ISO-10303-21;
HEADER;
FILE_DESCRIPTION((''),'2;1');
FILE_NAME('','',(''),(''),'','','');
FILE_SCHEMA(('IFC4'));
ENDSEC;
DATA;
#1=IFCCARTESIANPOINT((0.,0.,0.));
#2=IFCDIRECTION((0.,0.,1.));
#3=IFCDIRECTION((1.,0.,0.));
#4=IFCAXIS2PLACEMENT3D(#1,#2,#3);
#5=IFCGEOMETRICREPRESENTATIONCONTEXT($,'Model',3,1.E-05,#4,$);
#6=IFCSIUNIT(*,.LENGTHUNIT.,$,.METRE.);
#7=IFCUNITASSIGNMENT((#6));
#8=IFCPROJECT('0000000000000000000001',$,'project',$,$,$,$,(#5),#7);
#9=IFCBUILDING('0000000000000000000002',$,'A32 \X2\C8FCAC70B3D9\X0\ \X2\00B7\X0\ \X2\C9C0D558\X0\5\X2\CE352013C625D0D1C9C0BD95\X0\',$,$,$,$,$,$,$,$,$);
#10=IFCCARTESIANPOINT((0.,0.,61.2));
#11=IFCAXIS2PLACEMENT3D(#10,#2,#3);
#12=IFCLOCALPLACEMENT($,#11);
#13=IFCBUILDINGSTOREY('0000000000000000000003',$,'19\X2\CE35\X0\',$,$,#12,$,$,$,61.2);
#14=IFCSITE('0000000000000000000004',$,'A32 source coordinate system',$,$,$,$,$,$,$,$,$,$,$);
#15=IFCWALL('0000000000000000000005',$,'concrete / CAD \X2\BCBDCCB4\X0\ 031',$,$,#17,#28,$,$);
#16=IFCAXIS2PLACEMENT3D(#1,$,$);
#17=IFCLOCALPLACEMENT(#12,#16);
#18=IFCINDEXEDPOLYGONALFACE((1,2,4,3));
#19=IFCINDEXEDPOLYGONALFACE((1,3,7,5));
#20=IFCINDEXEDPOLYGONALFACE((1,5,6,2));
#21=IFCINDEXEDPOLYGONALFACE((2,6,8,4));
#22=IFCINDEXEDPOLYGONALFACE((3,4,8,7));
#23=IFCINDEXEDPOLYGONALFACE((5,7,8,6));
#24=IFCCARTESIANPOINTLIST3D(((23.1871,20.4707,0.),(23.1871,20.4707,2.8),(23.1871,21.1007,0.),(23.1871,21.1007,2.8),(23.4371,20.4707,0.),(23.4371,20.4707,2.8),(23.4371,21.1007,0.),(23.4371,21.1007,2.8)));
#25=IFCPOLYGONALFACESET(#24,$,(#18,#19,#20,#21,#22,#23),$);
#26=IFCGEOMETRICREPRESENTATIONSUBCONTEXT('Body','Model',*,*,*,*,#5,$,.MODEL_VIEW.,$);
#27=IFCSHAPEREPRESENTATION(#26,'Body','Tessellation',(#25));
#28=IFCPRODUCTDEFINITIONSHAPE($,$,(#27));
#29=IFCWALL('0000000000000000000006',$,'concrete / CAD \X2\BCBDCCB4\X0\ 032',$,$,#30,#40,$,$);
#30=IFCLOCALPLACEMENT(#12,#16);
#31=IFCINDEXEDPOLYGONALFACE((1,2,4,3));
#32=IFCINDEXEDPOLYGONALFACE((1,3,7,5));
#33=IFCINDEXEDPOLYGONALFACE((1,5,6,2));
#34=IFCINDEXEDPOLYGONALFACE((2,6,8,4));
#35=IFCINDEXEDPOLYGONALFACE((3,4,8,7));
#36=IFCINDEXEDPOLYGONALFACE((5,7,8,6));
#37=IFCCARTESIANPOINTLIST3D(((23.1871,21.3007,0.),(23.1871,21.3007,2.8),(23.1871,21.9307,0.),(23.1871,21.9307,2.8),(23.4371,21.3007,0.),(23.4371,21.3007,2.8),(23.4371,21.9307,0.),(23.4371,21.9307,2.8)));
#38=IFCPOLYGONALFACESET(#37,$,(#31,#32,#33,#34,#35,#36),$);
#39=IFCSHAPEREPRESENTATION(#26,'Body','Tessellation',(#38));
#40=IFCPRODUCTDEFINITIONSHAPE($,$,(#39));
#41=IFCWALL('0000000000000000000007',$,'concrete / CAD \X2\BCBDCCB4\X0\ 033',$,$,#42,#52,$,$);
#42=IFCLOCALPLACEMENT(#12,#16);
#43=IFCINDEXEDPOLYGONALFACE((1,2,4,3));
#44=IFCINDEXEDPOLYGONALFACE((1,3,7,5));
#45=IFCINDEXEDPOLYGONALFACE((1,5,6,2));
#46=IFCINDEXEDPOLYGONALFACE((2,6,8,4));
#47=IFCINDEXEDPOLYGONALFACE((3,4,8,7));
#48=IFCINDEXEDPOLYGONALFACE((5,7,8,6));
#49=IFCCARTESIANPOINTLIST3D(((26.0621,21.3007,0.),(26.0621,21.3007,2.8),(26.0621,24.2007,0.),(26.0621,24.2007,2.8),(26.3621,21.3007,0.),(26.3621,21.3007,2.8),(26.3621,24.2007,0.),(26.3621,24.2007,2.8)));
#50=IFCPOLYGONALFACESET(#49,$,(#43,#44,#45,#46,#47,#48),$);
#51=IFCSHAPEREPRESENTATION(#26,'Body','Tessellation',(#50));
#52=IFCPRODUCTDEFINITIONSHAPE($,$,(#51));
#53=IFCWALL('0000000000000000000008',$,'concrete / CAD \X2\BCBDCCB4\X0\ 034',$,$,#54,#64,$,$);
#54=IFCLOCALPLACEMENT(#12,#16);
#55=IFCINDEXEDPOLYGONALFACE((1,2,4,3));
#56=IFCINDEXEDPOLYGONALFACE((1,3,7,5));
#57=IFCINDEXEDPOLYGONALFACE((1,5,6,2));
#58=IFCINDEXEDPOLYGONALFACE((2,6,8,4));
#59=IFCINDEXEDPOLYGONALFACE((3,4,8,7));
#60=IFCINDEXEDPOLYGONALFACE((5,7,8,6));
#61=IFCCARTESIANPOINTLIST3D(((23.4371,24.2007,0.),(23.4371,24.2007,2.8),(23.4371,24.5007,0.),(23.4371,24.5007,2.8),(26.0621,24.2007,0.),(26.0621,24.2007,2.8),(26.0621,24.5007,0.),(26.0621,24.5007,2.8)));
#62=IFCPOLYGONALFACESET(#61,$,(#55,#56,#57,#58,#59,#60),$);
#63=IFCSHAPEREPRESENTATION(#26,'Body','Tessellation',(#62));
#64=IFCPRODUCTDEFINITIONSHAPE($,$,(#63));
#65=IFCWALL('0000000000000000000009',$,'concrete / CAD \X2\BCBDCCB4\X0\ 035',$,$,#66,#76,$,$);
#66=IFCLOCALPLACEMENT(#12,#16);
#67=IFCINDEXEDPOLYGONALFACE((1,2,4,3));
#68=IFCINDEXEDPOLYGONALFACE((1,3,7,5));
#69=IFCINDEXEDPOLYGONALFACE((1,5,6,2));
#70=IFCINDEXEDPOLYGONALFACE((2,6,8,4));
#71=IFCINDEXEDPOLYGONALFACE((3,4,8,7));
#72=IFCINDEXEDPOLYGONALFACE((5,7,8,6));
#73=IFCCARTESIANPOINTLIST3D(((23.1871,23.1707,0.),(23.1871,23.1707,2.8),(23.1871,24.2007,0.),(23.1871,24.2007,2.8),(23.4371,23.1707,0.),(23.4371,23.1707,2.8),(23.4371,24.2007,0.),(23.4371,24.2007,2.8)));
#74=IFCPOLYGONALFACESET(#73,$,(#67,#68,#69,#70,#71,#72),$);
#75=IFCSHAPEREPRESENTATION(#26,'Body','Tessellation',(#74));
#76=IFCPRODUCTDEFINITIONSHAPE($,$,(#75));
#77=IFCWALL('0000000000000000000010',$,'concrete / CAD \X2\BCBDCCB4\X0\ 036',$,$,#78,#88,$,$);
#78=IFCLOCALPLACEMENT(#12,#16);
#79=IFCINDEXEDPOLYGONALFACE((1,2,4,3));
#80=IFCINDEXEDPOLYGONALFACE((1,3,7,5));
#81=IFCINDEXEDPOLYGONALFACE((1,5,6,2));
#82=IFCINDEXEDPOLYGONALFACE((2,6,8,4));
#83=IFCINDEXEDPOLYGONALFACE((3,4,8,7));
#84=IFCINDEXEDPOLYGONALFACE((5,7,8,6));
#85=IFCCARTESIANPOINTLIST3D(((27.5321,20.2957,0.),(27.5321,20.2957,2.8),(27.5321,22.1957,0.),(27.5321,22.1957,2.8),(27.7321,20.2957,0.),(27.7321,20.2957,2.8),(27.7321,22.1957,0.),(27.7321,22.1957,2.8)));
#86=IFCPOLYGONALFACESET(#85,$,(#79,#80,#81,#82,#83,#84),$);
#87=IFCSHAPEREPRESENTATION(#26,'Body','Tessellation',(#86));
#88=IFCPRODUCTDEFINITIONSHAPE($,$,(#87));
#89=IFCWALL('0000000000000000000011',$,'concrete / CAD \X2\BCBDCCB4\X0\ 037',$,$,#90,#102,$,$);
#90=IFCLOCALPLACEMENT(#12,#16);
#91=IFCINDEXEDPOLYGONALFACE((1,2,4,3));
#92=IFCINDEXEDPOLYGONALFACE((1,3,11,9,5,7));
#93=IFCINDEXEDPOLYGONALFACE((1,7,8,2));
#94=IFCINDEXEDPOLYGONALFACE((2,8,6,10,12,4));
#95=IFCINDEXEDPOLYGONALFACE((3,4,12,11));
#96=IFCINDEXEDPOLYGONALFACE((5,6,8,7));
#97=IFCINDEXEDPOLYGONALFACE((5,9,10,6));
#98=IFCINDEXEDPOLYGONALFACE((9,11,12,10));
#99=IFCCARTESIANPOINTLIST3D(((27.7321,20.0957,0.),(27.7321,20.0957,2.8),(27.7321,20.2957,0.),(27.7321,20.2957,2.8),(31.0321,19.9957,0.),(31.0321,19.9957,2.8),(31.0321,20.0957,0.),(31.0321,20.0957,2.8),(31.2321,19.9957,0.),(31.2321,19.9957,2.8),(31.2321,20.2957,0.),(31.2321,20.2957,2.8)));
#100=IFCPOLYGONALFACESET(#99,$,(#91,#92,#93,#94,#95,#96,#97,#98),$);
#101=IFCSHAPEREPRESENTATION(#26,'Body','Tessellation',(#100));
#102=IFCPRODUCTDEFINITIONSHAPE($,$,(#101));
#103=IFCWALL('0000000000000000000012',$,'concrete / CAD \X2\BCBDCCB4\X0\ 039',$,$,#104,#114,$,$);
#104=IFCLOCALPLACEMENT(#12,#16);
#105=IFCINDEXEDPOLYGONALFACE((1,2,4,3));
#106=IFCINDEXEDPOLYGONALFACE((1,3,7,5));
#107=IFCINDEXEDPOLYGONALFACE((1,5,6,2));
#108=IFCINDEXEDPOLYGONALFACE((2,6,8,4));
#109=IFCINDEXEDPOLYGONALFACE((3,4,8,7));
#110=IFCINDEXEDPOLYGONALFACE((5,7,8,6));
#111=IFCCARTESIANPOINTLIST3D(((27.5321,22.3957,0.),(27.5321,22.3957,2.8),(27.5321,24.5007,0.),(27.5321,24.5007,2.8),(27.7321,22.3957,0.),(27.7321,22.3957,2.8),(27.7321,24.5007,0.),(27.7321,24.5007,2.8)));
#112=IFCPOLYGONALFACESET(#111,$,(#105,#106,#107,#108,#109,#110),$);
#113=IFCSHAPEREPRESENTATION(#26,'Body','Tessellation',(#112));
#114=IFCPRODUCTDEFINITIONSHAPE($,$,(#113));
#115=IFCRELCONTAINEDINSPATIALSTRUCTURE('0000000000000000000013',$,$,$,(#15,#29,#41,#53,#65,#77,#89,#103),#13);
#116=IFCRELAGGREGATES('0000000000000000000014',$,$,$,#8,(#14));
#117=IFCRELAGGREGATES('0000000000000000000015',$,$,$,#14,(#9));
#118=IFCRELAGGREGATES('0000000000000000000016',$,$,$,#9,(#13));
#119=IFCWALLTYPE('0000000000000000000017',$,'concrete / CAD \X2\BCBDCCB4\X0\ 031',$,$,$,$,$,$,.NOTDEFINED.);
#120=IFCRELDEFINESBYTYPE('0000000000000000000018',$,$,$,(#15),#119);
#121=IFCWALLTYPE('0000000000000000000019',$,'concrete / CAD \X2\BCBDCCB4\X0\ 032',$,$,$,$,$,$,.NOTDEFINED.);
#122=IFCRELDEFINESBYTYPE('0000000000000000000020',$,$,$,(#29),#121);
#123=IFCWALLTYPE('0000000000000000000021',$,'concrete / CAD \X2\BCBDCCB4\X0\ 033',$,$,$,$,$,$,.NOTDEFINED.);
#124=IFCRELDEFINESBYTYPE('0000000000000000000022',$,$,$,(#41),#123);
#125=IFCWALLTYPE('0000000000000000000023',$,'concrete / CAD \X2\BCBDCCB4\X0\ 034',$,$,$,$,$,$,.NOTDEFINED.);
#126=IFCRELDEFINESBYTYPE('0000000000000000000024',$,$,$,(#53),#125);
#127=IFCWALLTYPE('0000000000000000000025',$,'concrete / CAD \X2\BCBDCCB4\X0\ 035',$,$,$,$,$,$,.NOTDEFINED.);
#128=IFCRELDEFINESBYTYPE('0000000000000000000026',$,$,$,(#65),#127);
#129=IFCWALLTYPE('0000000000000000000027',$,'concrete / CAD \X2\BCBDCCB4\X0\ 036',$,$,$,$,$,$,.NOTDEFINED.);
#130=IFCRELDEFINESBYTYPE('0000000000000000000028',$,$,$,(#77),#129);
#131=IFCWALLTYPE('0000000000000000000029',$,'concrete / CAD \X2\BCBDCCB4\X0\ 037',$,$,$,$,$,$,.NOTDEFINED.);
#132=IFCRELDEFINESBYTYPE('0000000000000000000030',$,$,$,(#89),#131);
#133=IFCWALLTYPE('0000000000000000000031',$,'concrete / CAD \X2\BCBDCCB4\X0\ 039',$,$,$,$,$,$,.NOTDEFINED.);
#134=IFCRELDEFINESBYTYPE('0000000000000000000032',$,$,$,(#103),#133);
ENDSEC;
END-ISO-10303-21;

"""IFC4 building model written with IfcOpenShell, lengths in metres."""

from ifc_helpers import new_model, si_unit, frame, origin, origin_with_axes, place, context, subcontext, project, spatial, polyline, outline, extrude, source, transform, mapped, type_object, type_shapes, element, save


model = new_model("IFC4")

# Units and contexts
model_context = context("Model", 3, precision=1e-05, world=origin_with_axes())
body_context = subcontext(model_context, "Body", "Model", "MODEL_VIEW")
ifc_project = project(units=[si_unit("LENGTHUNIT", "METRE")], contexts=[model_context])

# Site, building, storey
site = spatial("IfcSite", under=ifc_project, Name="A32 source coordinate system")
building = spatial("IfcBuilding", under=site, Name="A32 주거동 · 지하5층–옥탑지붕")
storey_placement = place(None, frame((0.0, 0.0, 61.2), z_axis=(0.0, 0.0, 1.0), x_axis=(1.0, 0.0, 0.0)))
storey = spatial("IfcBuildingStorey", under=building, at=storey_placement, Name="19층", Elevation=61.2)

# Walls
wall_type_1 = type_object("IfcWallType", Name="concrete / CAD 벽체 031", PredefinedType="NOTDEFINED")
shared_shape_1 = source(origin(), body_context, "Body", "SweptSolid", [
    extrude(outline(polyline([(23.1871, 20.4707), (23.1871, 21.1007), (23.4371, 21.1007), (23.4371, 20.4707), (23.1871, 20.4707)])), origin(), (0.0, 0.0, 1.0), 2.8),
])
type_shapes(wall_type_1, [shared_shape_1])
wall_1_placement = place(storey_placement, origin_with_axes())
element("IfcWall", 1, at=wall_1_placement, inside=storey, type_object=wall_type_1, Name="concrete / CAD 벽체 031", context=body_context, shape_type="MappedRepresentation", body=[
    mapped(shared_shape_1, transform((0.0, 0.0, 0.0), scale=1.0)),
])
wall_type_2 = type_object("IfcWallType", Name="concrete / CAD 벽체 032", PredefinedType="NOTDEFINED")
shared_shape_2 = source(origin(), body_context, "Body", "SweptSolid", [
    extrude(outline(polyline([(23.4371, 21.9307), (23.4371, 21.3007), (23.1871, 21.3007), (23.1871, 21.9307), (23.4371, 21.9307)])), origin(), (0.0, 0.0, 1.0), 2.8),
])
type_shapes(wall_type_2, [shared_shape_2])
wall_2_placement = place(storey_placement, origin_with_axes())
element("IfcWall", 2, at=wall_2_placement, inside=storey, type_object=wall_type_2, Name="concrete / CAD 벽체 032", context=body_context, shape_type="MappedRepresentation", body=[
    mapped(shared_shape_2, transform((0.0, 0.0, 0.0), scale=1.0)),
])
wall_type_3 = type_object("IfcWallType", Name="concrete / CAD 벽체 033", PredefinedType="NOTDEFINED")
shared_shape_3 = source(origin(), body_context, "Body", "SweptSolid", [
    extrude(outline(polyline([(26.3621, 24.2007), (26.3621, 21.3007), (26.0621, 21.3007), (26.0621, 24.2007), (26.3621, 24.2007)])), origin(), (0.0, 0.0, 1.0), 2.8),
])
type_shapes(wall_type_3, [shared_shape_3])
wall_3_placement = place(storey_placement, origin_with_axes())
element("IfcWall", 3, at=wall_3_placement, inside=storey, type_object=wall_type_3, Name="concrete / CAD 벽체 033", context=body_context, shape_type="MappedRepresentation", body=[
    mapped(shared_shape_3, transform((0.0, 0.0, 0.0), scale=1.0)),
])
wall_type_4 = type_object("IfcWallType", Name="concrete / CAD 벽체 034", PredefinedType="NOTDEFINED")
shared_shape_4 = source(origin(), body_context, "Body", "SweptSolid", [
    extrude(outline(polyline([(23.4371, 24.5007), (26.0621, 24.5007), (26.0621, 24.2007), (23.4371, 24.2007), (23.4371, 24.5007)])), origin(), (0.0, 0.0, 1.0), 2.8),
])
type_shapes(wall_type_4, [shared_shape_4])
wall_4_placement = place(storey_placement, origin_with_axes())
element("IfcWall", 4, at=wall_4_placement, inside=storey, type_object=wall_type_4, Name="concrete / CAD 벽체 034", context=body_context, shape_type="MappedRepresentation", body=[
    mapped(shared_shape_4, transform((0.0, 0.0, 0.0), scale=1.0)),
])
wall_type_5 = type_object("IfcWallType", Name="concrete / CAD 벽체 035", PredefinedType="NOTDEFINED")
shared_shape_5 = source(origin(), body_context, "Body", "SweptSolid", [
    extrude(outline(polyline([(23.1871, 23.1707), (23.1871, 24.2007), (23.4371, 24.2007), (23.4371, 23.1707), (23.1871, 23.1707)])), origin(), (0.0, 0.0, 1.0), 2.8),
])
type_shapes(wall_type_5, [shared_shape_5])
wall_5_placement = place(storey_placement, origin_with_axes())
element("IfcWall", 5, at=wall_5_placement, inside=storey, type_object=wall_type_5, Name="concrete / CAD 벽체 035", context=body_context, shape_type="MappedRepresentation", body=[
    mapped(shared_shape_5, transform((0.0, 0.0, 0.0), scale=1.0)),
])
wall_type_6 = type_object("IfcWallType", Name="concrete / CAD 벽체 036", PredefinedType="NOTDEFINED")
shared_shape_6 = source(origin(), body_context, "Body", "SweptSolid", [
    extrude(outline(polyline([(27.7321, 22.1957), (27.7321, 20.2957), (27.5321, 20.2957), (27.5321, 22.1957), (27.7321, 22.1957)])), origin(), (0.0, 0.0, 1.0), 2.8),
])
type_shapes(wall_type_6, [shared_shape_6])
wall_6_placement = place(storey_placement, origin_with_axes())
element("IfcWall", 6, at=wall_6_placement, inside=storey, type_object=wall_type_6, Name="concrete / CAD 벽체 036", context=body_context, shape_type="MappedRepresentation", body=[
    mapped(shared_shape_6, transform((0.0, 0.0, 0.0), scale=1.0)),
])
wall_type_7 = type_object("IfcWallType", Name="concrete / CAD 벽체 037", PredefinedType="NOTDEFINED")
shared_shape_7 = source(origin(), body_context, "Body", "SweptSolid", [
    extrude(outline(polyline([(31.2321, 19.9957), (31.0321, 19.9957), (31.0321, 20.0957), (27.7321, 20.0957), (27.7321, 20.2957), (31.2321, 20.2957), (31.2321, 19.9957)])), origin(), (0.0, 0.0, 1.0), 2.8),
])
type_shapes(wall_type_7, [shared_shape_7])
wall_7_placement = place(storey_placement, origin_with_axes())
element("IfcWall", 7, at=wall_7_placement, inside=storey, type_object=wall_type_7, Name="concrete / CAD 벽체 037", context=body_context, shape_type="MappedRepresentation", body=[
    mapped(shared_shape_7, transform((0.0, 0.0, 0.0), scale=1.0)),
])
wall_type_8 = type_object("IfcWallType", Name="concrete / CAD 벽체 039", PredefinedType="NOTDEFINED")
shared_shape_8 = source(origin(), body_context, "Body", "SweptSolid", [
    extrude(outline(polyline([(27.7321, 24.5007), (27.7321, 22.3957), (27.5321, 22.3957), (27.5321, 24.5007), (27.7321, 24.5007)])), origin(), (0.0, 0.0, 1.0), 2.8),
])
type_shapes(wall_type_8, [shared_shape_8])
wall_8_placement = place(storey_placement, origin_with_axes())
element("IfcWall", 8, at=wall_8_placement, inside=storey, type_object=wall_type_8, Name="concrete / CAD 벽체 039", context=body_context, shape_type="MappedRepresentation", body=[
    mapped(shared_shape_8, transform((0.0, 0.0, 0.0), scale=1.0)),
])

save(model, "model.ifc")
